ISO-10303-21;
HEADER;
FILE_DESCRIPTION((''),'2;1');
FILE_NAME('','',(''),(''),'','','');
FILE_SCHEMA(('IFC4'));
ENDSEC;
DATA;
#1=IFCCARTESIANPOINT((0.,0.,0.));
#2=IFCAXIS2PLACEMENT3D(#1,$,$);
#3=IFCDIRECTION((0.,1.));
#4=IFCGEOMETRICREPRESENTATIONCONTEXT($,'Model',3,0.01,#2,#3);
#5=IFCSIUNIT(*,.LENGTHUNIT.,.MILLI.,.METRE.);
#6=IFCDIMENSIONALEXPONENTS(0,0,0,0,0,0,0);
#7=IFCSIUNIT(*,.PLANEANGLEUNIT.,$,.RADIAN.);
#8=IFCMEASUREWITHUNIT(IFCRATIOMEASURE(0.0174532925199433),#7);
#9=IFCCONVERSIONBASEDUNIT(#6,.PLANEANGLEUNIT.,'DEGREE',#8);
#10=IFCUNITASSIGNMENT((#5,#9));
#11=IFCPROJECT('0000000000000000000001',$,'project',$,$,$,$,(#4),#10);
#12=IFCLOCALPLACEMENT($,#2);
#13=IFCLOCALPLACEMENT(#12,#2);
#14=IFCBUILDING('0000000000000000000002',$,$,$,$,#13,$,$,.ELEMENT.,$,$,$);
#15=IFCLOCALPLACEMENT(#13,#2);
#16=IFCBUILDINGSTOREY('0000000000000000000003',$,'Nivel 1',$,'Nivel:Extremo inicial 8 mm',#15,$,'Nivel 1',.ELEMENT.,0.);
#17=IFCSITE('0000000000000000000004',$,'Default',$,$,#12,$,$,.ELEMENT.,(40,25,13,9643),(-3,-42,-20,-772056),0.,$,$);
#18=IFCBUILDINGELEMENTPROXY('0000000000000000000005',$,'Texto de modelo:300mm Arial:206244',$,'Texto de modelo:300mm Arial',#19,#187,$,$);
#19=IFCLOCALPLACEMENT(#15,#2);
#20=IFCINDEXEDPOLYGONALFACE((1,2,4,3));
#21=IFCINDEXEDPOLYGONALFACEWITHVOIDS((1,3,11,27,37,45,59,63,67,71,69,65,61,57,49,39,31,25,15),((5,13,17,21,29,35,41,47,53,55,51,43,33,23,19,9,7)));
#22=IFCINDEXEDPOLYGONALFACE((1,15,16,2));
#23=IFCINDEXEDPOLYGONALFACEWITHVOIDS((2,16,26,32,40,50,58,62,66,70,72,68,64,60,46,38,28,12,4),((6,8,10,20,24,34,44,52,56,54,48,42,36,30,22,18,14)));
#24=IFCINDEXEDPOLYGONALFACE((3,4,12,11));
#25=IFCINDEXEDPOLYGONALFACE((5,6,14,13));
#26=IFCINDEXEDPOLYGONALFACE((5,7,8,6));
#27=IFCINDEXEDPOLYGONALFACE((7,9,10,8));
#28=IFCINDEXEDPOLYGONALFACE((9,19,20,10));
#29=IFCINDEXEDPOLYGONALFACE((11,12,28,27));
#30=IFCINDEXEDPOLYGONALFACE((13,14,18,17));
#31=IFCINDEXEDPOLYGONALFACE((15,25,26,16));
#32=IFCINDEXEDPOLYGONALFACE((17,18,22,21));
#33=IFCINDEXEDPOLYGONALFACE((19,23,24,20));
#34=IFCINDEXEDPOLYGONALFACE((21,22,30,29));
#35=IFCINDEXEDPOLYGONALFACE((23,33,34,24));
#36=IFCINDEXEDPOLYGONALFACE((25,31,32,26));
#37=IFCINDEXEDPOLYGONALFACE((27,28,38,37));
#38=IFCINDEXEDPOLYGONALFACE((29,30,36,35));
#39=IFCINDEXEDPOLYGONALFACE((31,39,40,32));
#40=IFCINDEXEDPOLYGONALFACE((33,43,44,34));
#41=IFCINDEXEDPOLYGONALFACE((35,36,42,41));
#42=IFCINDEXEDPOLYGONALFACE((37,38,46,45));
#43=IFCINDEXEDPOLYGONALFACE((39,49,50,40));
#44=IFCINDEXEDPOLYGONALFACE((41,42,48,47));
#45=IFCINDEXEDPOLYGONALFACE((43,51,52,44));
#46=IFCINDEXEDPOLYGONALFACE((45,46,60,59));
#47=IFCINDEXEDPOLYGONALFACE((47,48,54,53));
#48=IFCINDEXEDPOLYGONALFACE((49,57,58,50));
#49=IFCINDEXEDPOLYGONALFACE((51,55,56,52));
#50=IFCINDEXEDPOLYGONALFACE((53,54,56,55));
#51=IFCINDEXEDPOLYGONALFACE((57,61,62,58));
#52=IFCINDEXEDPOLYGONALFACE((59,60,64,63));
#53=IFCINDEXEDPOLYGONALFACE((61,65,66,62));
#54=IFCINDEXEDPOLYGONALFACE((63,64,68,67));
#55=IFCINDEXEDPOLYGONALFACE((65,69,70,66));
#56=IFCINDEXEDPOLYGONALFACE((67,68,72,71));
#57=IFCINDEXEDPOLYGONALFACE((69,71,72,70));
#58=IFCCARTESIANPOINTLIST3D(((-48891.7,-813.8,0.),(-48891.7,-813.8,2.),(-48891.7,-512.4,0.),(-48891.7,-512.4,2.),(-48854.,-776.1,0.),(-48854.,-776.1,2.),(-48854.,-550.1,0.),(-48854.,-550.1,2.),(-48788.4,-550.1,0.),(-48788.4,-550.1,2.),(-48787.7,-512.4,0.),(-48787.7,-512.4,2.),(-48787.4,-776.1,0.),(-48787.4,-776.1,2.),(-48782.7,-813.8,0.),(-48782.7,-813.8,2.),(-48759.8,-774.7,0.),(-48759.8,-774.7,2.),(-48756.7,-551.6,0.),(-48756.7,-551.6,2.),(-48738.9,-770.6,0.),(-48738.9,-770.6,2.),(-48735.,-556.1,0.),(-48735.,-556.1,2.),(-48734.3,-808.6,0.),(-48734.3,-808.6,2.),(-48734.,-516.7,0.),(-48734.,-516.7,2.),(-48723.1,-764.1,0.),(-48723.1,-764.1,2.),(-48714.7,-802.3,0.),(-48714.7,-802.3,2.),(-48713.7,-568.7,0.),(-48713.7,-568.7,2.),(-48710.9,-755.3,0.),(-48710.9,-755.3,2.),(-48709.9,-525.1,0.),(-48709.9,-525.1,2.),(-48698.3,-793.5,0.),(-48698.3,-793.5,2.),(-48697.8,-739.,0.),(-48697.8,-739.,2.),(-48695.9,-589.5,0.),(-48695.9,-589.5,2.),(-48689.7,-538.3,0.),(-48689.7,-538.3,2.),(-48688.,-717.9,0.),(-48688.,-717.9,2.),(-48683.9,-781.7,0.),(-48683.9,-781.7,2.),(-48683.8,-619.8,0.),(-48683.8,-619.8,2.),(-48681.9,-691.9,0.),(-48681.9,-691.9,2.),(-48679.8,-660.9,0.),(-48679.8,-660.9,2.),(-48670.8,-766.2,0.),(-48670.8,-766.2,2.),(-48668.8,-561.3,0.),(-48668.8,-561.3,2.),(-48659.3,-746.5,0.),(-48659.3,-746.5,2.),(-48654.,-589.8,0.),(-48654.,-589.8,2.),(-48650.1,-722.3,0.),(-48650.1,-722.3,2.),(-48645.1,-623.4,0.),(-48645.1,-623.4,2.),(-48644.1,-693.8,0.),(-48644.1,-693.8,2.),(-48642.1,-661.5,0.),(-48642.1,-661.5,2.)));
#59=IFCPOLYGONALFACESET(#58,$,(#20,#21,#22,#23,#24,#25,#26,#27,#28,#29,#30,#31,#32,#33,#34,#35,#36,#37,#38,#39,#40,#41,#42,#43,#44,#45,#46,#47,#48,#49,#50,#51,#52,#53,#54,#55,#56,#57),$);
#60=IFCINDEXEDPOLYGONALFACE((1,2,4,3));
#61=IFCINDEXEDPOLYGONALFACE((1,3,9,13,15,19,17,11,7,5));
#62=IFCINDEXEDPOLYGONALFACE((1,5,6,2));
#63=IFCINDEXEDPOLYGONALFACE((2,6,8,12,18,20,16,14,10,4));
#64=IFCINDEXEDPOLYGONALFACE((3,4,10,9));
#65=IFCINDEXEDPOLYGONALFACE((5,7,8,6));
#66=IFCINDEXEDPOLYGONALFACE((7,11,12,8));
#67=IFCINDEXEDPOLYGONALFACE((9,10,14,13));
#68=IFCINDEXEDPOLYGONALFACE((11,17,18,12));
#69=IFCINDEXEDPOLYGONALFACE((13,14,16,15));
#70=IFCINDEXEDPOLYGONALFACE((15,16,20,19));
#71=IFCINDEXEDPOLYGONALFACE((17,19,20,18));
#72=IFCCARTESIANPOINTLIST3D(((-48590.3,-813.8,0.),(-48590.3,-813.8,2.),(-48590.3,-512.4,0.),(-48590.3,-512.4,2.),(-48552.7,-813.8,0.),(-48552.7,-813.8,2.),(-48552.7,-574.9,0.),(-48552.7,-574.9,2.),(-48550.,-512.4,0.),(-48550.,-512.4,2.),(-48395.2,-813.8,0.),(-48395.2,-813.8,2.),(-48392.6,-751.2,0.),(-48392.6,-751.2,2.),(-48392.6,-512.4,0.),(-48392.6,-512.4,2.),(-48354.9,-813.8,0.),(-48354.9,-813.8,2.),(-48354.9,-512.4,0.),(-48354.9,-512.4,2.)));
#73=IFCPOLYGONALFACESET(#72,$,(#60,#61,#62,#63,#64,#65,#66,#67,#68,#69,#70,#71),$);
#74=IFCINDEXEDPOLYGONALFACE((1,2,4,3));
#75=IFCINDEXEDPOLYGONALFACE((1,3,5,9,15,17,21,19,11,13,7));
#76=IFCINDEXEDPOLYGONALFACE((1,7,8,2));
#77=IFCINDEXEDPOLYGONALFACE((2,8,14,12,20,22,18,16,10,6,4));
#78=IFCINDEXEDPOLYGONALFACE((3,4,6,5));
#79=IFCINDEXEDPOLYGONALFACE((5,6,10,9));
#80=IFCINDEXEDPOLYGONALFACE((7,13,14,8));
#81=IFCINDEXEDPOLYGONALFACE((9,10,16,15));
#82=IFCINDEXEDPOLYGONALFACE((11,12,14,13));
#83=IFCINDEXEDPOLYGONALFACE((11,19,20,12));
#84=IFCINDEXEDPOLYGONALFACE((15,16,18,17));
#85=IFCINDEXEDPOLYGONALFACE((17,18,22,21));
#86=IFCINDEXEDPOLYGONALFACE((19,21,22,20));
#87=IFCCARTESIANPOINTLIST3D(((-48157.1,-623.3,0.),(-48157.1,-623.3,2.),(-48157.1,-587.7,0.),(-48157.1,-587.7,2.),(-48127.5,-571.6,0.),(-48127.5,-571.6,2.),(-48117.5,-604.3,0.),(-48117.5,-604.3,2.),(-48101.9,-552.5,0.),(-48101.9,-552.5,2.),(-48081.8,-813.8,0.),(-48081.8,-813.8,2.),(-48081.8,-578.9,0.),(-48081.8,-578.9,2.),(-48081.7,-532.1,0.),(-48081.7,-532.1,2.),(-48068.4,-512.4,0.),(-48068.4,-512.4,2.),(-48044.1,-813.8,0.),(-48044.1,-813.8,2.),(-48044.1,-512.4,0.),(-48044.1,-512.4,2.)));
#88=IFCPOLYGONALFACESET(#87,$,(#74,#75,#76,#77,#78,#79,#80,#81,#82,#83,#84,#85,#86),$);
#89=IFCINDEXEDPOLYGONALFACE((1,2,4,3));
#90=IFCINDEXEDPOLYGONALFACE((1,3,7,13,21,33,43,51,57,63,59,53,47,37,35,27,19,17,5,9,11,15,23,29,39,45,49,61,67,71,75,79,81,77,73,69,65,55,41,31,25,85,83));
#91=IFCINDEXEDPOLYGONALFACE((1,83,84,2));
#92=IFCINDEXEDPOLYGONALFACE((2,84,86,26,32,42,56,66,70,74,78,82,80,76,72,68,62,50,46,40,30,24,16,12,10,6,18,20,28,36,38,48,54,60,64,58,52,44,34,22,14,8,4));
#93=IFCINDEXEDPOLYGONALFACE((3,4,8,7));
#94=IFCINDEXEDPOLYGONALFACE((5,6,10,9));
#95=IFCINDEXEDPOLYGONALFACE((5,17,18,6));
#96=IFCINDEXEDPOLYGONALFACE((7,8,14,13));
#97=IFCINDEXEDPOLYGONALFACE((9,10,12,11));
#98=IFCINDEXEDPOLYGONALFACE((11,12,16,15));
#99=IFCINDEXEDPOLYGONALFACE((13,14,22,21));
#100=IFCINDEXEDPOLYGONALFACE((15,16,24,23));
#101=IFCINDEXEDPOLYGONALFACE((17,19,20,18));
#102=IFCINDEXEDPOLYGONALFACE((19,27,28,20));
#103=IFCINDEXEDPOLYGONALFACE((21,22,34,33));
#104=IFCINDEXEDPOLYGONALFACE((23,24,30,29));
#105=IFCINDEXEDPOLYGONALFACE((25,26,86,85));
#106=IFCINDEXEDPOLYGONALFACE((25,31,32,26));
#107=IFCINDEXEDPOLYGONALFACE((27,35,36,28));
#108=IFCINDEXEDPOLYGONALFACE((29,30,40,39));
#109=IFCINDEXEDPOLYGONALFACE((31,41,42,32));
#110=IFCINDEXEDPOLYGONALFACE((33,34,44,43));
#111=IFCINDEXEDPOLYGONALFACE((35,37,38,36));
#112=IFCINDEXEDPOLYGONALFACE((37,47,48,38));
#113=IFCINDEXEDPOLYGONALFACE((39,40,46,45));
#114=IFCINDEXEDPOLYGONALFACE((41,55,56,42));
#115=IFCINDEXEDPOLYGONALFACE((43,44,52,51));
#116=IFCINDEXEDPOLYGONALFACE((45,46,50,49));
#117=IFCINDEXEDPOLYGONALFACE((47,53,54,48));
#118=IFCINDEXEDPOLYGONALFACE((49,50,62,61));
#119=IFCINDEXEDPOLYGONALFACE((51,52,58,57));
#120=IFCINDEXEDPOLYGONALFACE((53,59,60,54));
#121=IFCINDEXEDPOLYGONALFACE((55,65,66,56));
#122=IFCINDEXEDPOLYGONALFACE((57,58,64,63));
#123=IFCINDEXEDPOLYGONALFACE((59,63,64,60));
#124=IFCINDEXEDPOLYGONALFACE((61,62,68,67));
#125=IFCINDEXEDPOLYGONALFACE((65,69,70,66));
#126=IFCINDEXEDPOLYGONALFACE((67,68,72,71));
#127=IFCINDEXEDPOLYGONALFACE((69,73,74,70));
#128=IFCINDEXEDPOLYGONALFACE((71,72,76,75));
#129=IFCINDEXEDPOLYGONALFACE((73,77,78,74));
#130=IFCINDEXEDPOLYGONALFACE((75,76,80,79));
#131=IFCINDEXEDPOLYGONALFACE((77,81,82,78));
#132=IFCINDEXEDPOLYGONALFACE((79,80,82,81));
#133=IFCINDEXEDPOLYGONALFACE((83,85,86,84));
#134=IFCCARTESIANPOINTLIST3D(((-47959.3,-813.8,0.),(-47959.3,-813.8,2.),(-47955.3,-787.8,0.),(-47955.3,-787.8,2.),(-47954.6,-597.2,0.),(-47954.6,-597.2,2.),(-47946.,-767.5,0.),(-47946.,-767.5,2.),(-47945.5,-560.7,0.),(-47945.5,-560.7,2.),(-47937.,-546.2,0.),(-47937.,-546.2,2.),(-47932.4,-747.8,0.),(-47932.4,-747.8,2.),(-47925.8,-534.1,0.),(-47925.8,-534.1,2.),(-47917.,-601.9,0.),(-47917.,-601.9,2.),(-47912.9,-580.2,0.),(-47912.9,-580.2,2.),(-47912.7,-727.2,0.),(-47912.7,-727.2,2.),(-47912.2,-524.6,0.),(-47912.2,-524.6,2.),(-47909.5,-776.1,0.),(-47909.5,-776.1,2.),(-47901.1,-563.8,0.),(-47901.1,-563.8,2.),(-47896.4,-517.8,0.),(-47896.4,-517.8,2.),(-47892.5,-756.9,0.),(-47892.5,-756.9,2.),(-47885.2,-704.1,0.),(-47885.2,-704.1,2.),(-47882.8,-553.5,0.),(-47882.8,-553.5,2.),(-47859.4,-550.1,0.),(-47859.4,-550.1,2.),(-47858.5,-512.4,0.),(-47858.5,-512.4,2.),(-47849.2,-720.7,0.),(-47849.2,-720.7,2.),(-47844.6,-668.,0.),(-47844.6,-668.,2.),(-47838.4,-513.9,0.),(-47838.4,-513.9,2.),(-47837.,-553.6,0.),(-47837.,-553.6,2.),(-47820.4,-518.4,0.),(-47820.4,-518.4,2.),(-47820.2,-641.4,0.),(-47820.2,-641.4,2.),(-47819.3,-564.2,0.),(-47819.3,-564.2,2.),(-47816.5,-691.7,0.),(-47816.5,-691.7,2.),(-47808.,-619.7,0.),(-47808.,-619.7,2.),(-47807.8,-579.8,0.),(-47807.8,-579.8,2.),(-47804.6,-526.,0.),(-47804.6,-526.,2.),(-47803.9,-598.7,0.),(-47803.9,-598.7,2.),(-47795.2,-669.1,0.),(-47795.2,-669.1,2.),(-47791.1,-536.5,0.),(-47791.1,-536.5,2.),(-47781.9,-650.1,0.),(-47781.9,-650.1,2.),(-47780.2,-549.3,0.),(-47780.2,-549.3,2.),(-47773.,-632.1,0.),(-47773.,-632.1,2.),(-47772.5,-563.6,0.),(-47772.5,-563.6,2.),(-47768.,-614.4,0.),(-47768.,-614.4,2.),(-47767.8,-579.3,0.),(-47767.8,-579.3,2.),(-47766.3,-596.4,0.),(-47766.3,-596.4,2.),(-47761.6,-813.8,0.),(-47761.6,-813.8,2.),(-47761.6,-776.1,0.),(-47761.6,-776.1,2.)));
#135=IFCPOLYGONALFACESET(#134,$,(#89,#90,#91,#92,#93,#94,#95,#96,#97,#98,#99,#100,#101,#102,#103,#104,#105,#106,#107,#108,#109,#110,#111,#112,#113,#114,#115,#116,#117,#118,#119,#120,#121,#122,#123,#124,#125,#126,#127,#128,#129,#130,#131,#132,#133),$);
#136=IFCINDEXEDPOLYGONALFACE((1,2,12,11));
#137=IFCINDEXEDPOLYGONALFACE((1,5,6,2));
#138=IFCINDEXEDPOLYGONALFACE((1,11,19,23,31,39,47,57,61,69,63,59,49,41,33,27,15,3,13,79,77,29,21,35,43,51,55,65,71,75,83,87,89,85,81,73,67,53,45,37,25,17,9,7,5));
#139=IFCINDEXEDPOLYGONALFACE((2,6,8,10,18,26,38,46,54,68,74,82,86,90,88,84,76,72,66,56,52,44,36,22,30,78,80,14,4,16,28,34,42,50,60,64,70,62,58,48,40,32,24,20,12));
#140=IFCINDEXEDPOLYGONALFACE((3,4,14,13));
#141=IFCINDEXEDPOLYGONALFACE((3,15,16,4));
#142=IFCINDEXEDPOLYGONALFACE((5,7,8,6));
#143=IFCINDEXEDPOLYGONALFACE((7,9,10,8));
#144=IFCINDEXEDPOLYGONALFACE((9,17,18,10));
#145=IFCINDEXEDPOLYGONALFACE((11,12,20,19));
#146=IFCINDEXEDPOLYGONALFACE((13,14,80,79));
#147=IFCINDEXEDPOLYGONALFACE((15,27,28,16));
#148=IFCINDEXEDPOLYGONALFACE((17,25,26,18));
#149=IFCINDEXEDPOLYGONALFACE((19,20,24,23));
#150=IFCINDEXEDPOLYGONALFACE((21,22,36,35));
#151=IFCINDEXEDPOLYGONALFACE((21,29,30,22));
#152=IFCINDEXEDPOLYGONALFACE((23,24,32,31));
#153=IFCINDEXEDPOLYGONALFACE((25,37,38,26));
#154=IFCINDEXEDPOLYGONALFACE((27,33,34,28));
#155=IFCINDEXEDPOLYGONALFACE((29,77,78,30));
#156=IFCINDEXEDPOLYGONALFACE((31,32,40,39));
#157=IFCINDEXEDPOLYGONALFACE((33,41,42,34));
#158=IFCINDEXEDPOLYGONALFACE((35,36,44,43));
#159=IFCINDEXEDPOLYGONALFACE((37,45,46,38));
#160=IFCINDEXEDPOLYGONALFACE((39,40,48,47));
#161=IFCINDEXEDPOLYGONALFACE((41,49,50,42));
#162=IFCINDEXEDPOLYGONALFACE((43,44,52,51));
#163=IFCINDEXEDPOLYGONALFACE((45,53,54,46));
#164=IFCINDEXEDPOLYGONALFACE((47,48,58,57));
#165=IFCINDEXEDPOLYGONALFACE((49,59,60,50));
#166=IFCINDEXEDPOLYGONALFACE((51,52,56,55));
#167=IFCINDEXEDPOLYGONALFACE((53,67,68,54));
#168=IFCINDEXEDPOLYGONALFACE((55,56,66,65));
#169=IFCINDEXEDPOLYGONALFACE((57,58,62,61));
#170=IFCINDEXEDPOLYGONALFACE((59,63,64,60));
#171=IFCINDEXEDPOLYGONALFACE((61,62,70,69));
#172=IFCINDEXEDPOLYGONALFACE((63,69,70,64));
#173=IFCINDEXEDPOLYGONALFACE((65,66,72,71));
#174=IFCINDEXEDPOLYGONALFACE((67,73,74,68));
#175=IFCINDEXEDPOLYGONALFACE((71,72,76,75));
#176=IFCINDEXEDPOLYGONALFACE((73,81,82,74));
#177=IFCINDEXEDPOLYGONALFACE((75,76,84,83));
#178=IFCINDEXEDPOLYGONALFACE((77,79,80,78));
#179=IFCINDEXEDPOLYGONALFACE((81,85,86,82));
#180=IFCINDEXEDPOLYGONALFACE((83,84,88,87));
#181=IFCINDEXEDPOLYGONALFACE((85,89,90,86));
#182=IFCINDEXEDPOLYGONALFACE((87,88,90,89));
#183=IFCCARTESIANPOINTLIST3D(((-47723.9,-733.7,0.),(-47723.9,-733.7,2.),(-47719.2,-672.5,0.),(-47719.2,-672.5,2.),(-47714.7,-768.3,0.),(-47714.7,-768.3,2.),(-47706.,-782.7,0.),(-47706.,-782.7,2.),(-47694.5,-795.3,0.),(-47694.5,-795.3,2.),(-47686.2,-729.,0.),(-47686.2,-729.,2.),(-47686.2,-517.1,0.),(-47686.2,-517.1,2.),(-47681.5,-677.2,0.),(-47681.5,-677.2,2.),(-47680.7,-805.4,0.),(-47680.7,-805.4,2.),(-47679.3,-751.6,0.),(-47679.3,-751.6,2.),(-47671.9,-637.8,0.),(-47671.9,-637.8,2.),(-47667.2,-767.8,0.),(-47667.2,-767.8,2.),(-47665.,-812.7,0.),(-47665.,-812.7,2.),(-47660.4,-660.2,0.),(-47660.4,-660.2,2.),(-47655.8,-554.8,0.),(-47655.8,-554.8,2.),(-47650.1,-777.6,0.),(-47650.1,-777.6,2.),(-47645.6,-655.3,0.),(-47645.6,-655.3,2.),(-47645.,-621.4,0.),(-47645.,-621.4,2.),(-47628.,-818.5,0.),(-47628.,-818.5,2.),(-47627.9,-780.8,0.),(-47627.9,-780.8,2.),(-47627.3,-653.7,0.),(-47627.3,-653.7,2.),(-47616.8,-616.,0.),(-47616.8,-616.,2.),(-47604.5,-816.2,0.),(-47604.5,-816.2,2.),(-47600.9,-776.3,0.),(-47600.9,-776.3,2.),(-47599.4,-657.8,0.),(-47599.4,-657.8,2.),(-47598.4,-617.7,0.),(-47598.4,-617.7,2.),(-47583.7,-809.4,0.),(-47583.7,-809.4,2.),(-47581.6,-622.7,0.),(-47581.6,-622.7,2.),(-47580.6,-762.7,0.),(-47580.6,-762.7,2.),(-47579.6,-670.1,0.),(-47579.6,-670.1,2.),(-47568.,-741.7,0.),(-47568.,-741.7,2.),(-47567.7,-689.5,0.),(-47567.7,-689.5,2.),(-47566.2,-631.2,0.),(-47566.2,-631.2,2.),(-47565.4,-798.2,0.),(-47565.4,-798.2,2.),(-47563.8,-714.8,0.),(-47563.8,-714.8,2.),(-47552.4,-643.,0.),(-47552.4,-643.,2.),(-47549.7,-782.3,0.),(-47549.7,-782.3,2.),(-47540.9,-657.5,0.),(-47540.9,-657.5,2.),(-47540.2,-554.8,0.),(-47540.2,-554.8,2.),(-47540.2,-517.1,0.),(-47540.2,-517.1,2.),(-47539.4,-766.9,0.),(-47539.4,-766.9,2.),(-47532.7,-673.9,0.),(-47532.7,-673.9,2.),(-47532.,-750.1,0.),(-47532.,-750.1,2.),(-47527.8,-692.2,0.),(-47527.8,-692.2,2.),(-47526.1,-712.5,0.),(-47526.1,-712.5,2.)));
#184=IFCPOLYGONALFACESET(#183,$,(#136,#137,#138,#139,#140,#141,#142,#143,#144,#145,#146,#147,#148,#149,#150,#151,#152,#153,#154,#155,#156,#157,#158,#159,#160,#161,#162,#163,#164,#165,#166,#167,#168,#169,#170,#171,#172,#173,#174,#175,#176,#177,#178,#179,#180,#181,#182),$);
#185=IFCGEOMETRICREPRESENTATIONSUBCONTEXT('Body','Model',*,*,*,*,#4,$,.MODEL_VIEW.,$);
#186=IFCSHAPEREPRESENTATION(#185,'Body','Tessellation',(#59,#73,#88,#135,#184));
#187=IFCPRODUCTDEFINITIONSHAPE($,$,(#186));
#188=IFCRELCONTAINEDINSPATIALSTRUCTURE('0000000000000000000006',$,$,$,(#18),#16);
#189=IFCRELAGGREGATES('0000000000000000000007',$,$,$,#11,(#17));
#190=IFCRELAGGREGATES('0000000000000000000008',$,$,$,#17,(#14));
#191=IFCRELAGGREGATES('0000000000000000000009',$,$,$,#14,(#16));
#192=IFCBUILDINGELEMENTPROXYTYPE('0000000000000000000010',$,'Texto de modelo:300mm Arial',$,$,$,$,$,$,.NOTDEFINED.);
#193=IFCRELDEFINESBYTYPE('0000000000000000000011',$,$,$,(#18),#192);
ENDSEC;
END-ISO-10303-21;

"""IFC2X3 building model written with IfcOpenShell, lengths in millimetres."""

from ifc_helpers import new_model, entity, si_unit, converted_unit, direction, frame, origin, place, context, subcontext, project, spatial, polyline, outline, extrude, type_object, element, save


model = new_model("IFC2X3")

# Units and contexts
model_context = context("Model", 3, precision=0.01, world=origin(), true_north=direction((0.0, 1.0)))
body_context = subcontext(model_context, "Body", "Model", "MODEL_VIEW")
ifc_project = project(units=[si_unit("LENGTHUNIT", "METRE", prefix="MILLI"), converted_unit("PLANEANGLEUNIT", "DEGREE", entity("IfcRatioMeasure", 0.0174532925199433), si_unit("PLANEANGLEUNIT", "RADIAN"), dimensions=[0, 0, 0, 0, 0, 0, 0])], contexts=[model_context])

# Site, building, storey
site_placement = place(None, origin())
site = spatial("IfcSite", under=ifc_project, at=site_placement, Name="Default", CompositionType="ELEMENT", RefLatitude=(40, 25, 13, 9643), RefLongitude=(-3, -42, -20, -772056), RefElevation=0.0)
building_placement = place(site_placement, origin())
building = spatial("IfcBuilding", under=site, at=building_placement, CompositionType="ELEMENT")
storey_placement = place(building_placement, origin())
storey = spatial("IfcBuildingStorey", under=building, at=storey_placement, Name="Nivel 1", ObjectType="Nivel:Extremo inicial 8 mm", LongName="Nivel 1", CompositionType="ELEMENT", Elevation=0.0)

# Building element proxy
building_element_proxy_type_1 = type_object("IfcBuildingElementProxyType", Name="Texto de modelo:300mm Arial", PredefinedType="NOTDEFINED")
proxy_1_placement = place(storey_placement, frame((-48891.7, -818.5, 0.0)))
element("IfcBuildingElementProxy", 1, at=proxy_1_placement, inside=storey, type_object=building_element_proxy_type_1, Name="Texto de modelo:300mm Arial:206244", ObjectType="Texto de modelo:300mm Arial", context=body_context, shape_type="SweptSolid", body=[
    extrude(outline(polyline([(-178.4, -141.0), (-69.4, -141.0), (-21.0, -135.8), (-1.4, -129.5), (15.0, -120.7), (29.4, -108.9), (42.6, -93.4), (54.0, -73.7), (63.2, -49.5), (69.2, -21.0), (71.2, 11.3), (68.2, 49.4), (59.3, 83.0), (44.5, 111.5), (23.7, 134.5), (3.4, 147.7), (-20.6, 156.1), (-74.4, 160.4), (-178.4, 160.4), (-178.4, -141.0)]), holes=[polyline([(-140.7, -103.3), (-140.7, 122.7), (-75.1, 122.7), (-43.3, 121.2), (-21.7, 116.7), (-0.4, 104.1), (17.4, 83.3), (29.5, 53.0), (33.5, 11.9), (31.5, -19.1), (25.3, -45.1), (15.5, -66.2), (2.4, -82.5), (-9.8, -91.3), (-25.6, -97.9), (-46.5, -101.9), (-74.1, -103.3), (-140.7, -103.3)])]), frame((178.4, 145.7, 0.0)), (0.0, 0.0, 1.0), 2.0),
    extrude(outline(polyline([(-117.7, -150.7), (-80.1, -150.7), (-80.1, 88.1), (77.4, -150.7), (117.7, -150.7), (117.7, 150.7), (80.1, 150.7), (80.1, -88.1), (-77.4, 150.7), (-117.7, 150.7), (-117.7, -150.7)])), frame((419.1, 155.4, 0.0)), (0.0, 0.0, 1.0), 2.0),
    extrude(outline(polyline([(-204.4, -52.5), (97.0, -52.5), (97.0, -28.2), (77.2, -14.9), (56.9, 5.3), (37.7, 30.9), (21.6, 60.5), (-14.0, 60.5), (5.0, 20.8), (30.4, -14.9), (-204.4, -14.9), (-204.4, -52.5)])), frame((795.1, 209.1, 0.0), z_axis=(0.0, 0.0, 1.0), x_axis=(0.0, 1.0, 0.0)), (0.0, 0.0, 1.0), 2.0),
    extrude(outline(polyline([(-91.6, -150.5), (-91.6, -188.2), (106.2, -188.2), (102.1, -162.2), (92.9, -141.9), (79.3, -122.2), (59.6, -101.6), (32.1, -78.5), (-8.5, -42.4), (-32.9, -15.8), (-45.1, 5.8), (-49.2, 26.9), (-45.4, 45.8), (-33.9, 61.4), (-16.2, 72.0), (6.2, 75.5), (29.7, 72.1), (48.0, 61.8), (59.7, 45.4), (63.8, 23.7), (101.5, 28.4), (92.4, 64.9), (83.8, 79.4), (72.6, 91.5), (59.0, 101.0), (43.3, 107.8), (5.4, 113.2), (-14.8, 111.7), (-32.8, 107.2), (-48.5, 99.6), (-62.0, 89.1), (-72.9, 76.3), (-80.7, 62.0), (-85.3, 46.3), (-86.9, 29.2), (-85.2, 11.2), (-80.2, -6.5), (-71.3, -24.6), (-57.9, -43.5), (-36.6, -66.1), (-3.9, -95.1), (39.4, -131.3), (56.4, -150.5), (-91.6, -150.5)])), frame((1038.6, 192.9, 0.0), z_axis=(0.0, 0.0, -1.0), x_axis=(-1.0, 0.0, 0.0)), (0.0, 0.0, -1.0), 2.0),
    extrude(outline(polyline([(1.4, -113.1), (37.2, -113.1), (53.4, -108.4), (68.5, -100.5), (81.8, -89.8), (92.9, -76.5), (108.0, -42.2), (111.8, -18.9), (110.6, 3.0), (104.4, 23.5), (93.2, 42.7), (80.9, 56.7), (66.6, 68.1), (31.7, 83.5), (11.7, 87.1), (-7.3, 87.1), (-25.2, 83.4), (-42.2, 76.0), (-57.1, 65.7), (-69.2, 53.0), (-78.5, 38.0), (-84.8, 20.7), (-86.8, -7.9), (-77.9, -38.1), (-154.0, -1.2), (-124.3, 110.4), (-160.7, 120.1), (-198.2, -21.0), (-56.5, -92.8), (-42.3, -57.6), (-53.3, -32.8), (-54.2, -17.2), (-51.1, 0.9), (-40.0, 26.8), (-23.0, 42.8), (-1.2, 49.2), (24.3, 46.5), (49.2, 35.5), (66.3, 17.9), (74.2, -5.1), (71.6, -32.4), (62.8, -53.0), (48.9, -67.1), (30.2, -74.6), (6.6, -75.5), (1.4, -113.1)])), frame((1276.7, 115.2, 0.0), z_axis=(0.0, 0.0, 1.0), x_axis=(0.256974, -0.966418, 0.0)), (0.0, 0.0, 1.0), 2.0),
])

save(model, "model.ifc")
